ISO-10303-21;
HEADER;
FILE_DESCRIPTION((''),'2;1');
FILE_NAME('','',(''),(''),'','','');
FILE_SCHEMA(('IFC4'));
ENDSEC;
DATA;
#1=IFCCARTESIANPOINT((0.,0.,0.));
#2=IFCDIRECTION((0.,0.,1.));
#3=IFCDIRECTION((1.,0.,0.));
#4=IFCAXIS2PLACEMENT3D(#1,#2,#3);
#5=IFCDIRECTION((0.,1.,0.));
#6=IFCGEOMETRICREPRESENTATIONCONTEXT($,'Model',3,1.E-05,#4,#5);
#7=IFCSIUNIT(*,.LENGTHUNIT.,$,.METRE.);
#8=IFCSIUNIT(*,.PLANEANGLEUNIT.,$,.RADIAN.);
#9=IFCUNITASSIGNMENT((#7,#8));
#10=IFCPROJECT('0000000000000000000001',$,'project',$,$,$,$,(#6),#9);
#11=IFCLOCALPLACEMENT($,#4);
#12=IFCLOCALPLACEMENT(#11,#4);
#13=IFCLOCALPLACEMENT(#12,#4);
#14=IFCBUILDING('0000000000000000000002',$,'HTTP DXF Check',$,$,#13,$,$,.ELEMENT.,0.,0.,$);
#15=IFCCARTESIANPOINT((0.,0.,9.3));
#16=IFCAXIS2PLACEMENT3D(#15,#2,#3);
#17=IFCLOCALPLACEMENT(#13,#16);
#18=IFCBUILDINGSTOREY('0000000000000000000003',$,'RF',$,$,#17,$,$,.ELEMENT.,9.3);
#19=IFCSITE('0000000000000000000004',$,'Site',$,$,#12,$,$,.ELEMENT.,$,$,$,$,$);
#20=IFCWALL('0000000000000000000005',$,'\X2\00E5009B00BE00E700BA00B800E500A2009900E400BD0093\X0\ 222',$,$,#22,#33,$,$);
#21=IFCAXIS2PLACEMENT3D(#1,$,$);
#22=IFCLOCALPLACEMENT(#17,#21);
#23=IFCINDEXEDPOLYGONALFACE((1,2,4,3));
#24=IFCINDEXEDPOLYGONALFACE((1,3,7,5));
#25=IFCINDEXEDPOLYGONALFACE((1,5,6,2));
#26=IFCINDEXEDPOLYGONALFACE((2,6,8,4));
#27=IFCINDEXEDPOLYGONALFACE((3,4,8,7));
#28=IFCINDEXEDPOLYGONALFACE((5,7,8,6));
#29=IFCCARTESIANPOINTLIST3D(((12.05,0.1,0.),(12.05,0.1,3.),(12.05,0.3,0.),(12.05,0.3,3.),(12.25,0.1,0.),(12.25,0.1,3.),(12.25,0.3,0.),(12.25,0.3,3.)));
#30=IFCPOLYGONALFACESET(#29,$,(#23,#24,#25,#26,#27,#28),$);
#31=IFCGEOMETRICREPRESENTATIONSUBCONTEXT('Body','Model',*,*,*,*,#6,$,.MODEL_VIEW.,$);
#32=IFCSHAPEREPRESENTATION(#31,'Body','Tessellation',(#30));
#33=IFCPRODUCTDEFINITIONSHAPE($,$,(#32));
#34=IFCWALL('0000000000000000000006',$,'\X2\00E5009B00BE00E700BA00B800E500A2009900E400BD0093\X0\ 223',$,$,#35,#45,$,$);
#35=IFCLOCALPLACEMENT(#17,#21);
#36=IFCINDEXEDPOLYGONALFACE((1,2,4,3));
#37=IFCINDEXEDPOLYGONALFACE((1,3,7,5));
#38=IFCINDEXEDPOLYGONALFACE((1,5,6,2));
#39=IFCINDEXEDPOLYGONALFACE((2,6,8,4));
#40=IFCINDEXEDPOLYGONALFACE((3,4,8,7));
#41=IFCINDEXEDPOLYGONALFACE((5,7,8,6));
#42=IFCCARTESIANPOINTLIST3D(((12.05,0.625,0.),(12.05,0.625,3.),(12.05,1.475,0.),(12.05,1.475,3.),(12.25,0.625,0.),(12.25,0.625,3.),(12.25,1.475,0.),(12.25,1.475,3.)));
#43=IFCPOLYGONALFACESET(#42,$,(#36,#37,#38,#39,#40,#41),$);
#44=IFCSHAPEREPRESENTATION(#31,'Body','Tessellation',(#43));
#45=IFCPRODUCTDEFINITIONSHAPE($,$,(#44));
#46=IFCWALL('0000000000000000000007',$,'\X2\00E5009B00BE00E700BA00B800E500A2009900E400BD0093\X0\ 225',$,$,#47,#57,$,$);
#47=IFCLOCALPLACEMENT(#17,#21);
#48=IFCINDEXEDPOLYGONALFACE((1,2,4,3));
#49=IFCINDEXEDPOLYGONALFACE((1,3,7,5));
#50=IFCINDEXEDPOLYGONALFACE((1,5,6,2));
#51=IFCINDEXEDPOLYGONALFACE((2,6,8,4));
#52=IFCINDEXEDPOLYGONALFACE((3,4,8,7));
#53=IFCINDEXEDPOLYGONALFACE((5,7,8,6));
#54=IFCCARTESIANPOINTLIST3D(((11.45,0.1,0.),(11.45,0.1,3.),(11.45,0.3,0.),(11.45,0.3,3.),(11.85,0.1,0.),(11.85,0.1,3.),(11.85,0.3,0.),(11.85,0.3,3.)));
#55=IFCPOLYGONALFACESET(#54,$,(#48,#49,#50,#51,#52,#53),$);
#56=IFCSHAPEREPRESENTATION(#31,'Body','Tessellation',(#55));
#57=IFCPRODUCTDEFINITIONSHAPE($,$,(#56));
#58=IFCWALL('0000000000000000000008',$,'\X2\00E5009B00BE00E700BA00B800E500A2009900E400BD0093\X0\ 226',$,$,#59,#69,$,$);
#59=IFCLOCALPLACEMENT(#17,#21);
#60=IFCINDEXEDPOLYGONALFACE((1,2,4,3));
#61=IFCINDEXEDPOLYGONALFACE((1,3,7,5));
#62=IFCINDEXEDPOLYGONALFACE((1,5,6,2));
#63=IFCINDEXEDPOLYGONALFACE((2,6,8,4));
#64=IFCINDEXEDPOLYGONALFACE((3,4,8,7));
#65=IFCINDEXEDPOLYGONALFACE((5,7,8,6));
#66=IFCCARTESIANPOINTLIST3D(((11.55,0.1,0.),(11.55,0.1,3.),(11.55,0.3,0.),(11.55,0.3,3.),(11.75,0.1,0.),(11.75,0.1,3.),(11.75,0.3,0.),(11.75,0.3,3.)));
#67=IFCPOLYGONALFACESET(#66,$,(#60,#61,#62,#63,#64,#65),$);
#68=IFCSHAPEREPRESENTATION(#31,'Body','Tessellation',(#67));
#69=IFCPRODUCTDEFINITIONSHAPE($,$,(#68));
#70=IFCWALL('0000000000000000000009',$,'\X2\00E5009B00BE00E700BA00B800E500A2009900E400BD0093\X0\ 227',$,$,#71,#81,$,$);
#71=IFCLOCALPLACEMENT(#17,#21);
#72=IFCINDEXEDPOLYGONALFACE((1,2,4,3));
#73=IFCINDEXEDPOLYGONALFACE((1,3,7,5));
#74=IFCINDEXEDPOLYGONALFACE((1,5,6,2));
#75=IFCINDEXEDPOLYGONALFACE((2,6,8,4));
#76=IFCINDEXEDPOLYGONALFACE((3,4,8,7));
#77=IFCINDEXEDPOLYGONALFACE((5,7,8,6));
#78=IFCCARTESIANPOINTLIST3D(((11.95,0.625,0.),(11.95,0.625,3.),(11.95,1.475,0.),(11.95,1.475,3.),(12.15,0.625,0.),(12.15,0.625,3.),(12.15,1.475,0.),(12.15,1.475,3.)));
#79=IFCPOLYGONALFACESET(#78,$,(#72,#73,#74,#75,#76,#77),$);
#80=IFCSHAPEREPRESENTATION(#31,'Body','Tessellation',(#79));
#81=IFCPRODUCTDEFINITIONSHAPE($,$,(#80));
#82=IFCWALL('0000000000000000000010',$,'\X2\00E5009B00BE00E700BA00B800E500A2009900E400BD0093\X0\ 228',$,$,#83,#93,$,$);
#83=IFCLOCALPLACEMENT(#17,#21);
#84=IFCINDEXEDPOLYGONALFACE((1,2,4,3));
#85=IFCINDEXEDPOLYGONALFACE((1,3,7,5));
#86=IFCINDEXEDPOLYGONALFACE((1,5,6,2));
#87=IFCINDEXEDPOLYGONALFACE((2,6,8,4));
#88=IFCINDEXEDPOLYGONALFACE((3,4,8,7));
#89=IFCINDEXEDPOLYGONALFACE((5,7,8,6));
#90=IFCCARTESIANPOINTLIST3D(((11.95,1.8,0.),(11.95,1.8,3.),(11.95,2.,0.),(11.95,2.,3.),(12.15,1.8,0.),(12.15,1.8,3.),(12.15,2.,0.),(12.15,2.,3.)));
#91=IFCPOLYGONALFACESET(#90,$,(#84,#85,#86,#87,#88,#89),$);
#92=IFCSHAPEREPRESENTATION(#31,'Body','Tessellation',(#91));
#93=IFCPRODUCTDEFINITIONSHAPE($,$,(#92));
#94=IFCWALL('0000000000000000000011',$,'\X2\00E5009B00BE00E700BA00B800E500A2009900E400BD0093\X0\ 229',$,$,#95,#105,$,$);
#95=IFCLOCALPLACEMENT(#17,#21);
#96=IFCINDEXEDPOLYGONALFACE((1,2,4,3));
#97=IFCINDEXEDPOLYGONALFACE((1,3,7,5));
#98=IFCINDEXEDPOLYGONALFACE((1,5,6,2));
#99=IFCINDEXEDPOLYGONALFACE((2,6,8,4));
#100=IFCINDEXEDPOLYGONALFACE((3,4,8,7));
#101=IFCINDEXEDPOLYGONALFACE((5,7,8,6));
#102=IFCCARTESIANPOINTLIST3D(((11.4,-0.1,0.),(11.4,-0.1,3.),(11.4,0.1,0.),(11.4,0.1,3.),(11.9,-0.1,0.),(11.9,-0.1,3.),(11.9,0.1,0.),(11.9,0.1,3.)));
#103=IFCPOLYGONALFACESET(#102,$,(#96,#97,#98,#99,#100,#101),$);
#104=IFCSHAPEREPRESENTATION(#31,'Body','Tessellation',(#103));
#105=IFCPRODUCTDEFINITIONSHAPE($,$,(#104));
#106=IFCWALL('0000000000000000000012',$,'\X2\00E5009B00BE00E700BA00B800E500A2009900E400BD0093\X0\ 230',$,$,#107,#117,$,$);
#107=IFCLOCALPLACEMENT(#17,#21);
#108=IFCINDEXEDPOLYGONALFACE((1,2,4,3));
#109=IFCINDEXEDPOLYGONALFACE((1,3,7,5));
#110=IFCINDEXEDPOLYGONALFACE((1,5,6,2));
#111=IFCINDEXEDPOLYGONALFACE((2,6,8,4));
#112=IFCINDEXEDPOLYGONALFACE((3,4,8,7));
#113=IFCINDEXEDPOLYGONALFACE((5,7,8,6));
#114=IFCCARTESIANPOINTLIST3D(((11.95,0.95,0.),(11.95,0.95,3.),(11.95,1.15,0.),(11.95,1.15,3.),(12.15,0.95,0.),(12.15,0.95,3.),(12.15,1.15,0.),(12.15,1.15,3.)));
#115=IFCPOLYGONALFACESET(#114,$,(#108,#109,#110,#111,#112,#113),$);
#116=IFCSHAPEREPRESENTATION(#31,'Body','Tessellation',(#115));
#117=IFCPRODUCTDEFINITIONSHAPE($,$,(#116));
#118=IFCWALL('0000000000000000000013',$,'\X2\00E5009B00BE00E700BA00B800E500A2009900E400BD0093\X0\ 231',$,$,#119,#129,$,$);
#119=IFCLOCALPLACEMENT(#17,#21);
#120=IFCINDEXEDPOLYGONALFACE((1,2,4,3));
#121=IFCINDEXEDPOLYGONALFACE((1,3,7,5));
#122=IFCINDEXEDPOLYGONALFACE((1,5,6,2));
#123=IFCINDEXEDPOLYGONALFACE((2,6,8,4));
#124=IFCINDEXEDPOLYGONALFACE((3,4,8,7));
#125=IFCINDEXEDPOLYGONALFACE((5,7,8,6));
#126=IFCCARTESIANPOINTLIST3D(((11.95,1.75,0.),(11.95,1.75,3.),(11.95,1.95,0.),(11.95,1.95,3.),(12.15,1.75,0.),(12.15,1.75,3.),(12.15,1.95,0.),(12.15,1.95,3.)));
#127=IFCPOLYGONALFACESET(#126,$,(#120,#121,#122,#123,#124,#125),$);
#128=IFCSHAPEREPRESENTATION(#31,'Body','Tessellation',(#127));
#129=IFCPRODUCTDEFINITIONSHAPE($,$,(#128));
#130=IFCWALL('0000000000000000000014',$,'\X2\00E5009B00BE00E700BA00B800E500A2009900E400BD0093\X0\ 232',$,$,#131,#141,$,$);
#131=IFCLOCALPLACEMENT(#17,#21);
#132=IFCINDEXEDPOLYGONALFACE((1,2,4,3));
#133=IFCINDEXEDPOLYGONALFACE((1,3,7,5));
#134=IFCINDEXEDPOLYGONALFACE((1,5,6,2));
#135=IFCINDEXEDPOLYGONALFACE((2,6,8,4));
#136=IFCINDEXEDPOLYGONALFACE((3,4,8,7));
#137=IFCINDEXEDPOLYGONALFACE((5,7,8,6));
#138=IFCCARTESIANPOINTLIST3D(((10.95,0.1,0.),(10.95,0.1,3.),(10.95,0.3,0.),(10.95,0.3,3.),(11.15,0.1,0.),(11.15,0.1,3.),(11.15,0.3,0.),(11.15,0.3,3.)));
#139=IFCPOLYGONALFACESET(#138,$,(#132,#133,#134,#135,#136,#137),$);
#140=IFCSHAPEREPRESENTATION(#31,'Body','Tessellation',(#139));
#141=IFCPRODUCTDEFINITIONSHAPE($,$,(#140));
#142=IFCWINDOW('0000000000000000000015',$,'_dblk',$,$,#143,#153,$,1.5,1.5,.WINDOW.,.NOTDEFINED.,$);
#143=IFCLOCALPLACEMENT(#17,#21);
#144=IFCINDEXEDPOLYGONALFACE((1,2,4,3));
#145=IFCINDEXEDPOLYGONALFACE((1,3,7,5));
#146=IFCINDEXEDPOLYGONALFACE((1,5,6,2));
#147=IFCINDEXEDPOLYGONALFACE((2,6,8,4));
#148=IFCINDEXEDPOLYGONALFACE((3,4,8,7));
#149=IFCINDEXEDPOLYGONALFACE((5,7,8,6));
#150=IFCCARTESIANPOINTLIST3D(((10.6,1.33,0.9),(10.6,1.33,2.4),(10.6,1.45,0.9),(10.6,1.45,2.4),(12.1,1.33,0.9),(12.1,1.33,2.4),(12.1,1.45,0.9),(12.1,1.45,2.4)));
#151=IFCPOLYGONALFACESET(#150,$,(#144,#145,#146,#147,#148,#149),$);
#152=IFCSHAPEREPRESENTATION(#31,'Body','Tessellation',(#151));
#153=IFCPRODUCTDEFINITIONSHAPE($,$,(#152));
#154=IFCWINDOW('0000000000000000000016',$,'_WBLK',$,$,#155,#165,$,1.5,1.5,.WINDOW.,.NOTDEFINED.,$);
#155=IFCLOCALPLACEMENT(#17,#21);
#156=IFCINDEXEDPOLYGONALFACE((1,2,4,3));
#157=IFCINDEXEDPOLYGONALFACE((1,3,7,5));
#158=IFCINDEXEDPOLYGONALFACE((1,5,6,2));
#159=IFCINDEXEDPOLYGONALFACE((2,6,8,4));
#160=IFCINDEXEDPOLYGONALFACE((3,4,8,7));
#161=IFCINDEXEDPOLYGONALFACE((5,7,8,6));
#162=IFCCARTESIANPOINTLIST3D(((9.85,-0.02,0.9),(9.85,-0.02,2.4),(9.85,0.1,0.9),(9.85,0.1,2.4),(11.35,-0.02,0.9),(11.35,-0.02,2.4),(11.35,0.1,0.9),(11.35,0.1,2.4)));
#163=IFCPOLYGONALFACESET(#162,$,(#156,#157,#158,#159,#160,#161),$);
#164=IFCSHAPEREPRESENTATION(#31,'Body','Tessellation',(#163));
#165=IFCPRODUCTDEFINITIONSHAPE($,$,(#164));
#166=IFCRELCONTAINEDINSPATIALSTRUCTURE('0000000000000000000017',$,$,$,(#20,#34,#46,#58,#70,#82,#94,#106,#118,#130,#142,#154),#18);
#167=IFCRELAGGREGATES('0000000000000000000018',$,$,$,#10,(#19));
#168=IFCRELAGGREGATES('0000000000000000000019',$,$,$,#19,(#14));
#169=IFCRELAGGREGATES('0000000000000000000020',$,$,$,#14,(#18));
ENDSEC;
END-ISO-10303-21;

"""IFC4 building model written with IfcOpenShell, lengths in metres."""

from ifc_helpers import new_model, si_unit, direction, frame, frame_2d, origin_with_axes, place, context, subcontext, project, spatial, rectangle, extrude, element, save


model = new_model("IFC4")

# Units and contexts
model_context = context("Model", 3, precision=1e-05, world=origin_with_axes(), true_north=direction((0.0, 1.0, 0.0)))
body_context = subcontext(model_context, "Body", "Model", "MODEL_VIEW")
ifc_project = project(units=[si_unit("LENGTHUNIT", "METRE"), si_unit("PLANEANGLEUNIT", "RADIAN")], contexts=[model_context])

# Site, building, storey
placement = place(None, origin_with_axes())
site_placement = place(placement, origin_with_axes())
site = spatial("IfcSite", under=ifc_project, at=site_placement, Name="Site", CompositionType="ELEMENT")
building_placement = place(site_placement, origin_with_axes())
building = spatial("IfcBuilding", under=site, at=building_placement, Name="HTTP DXF Check", CompositionType="ELEMENT", ElevationOfRefHeight=0.0, ElevationOfTerrain=0.0)
storey_placement = place(building_placement, frame((0.0, 0.0, 9.3), z_axis=(0.0, 0.0, 1.0), x_axis=(1.0, 0.0, 0.0)))
storey = spatial("IfcBuildingStorey", under=building, at=storey_placement, Name="RF", CompositionType="ELEMENT", Elevation=9.3)

# Walls
for number, where, z_axis, x_axis, name in (
    (1, (12.15, 0.2, 0.0), (0.0, 0.0, 1.0), (0.0, -1.0, 0.0), "å\u009b¾çº¸å¢\u0099ä½\u0093 222"),
):
    element("IfcWall", number, at=place(storey_placement, frame(where, z_axis=z_axis, x_axis=x_axis)), inside=storey, Name=name, context=body_context, shape_type="SweptSolid", body=[
        extrude(rectangle(XDim=0.2, YDim=0.2, at=frame_2d((0.0, 0.0), x_axis=(1.0, 0.0, 0.0))), frame((0.0, 0.0, 0.0), z_axis=(0.0, 0.0, 1.0)), (0.0, 0.0, 1.0), 3.0),
    ])
wall_1_placement = place(storey_placement, frame((12.15, 1.05, 0.0), z_axis=(0.0, 0.0, 1.0), x_axis=(0.0, -1.0, 0.0)))
element("IfcWall", 2, at=wall_1_placement, inside=storey, Name="å\u009b¾çº¸å¢\u0099ä½\u0093 223", context=body_context, shape_type="SweptSolid", body=[
    extrude(rectangle(XDim=0.85, YDim=0.2, at=frame_2d((0.0, 0.0), x_axis=(1.0, 0.0, 0.0))), frame((0.0, 0.0, 0.0), z_axis=(0.0, 0.0, 1.0)), (0.0, 0.0, 1.0), 3.0),
])
wall_2_placement = place(storey_placement, frame((11.65, 0.2, 0.0), z_axis=(0.0, 0.0, 1.0), x_axis=(1.0, 0.0, 0.0)))
element("IfcWall", 3, at=wall_2_placement, inside=storey, Name="å\u009b¾çº¸å¢\u0099ä½\u0093 225", context=body_context, shape_type="SweptSolid", body=[
    extrude(rectangle(XDim=0.4, YDim=0.2, at=frame_2d((0.0, 0.0), x_axis=(1.0, 0.0, 0.0))), frame((0.0, 0.0, 0.0), z_axis=(0.0, 0.0, 1.0)), (0.0, 0.0, 1.0), 3.0),
])
wall_3_placement = place(storey_placement, frame((11.65, 0.2, 0.0), z_axis=(0.0, 0.0, 1.0), x_axis=(0.0, -1.0, 0.0)))
element("IfcWall", 4, at=wall_3_placement, inside=storey, Name="å\u009b¾çº¸å¢\u0099ä½\u0093 226", context=body_context, shape_type="SweptSolid", body=[
    extrude(rectangle(XDim=0.2, YDim=0.2, at=frame_2d((0.0, 0.0), x_axis=(1.0, 0.0, 0.0))), frame((0.0, 0.0, 0.0), z_axis=(0.0, 0.0, 1.0)), (0.0, 0.0, 1.0), 3.0),
])
wall_4_placement = place(storey_placement, frame((12.05, 1.05, 0.0), z_axis=(0.0, 0.0, 1.0), x_axis=(0.0, -1.0, 0.0)))
element("IfcWall", 5, at=wall_4_placement, inside=storey, Name="å\u009b¾çº¸å¢\u0099ä½\u0093 227", context=body_context, shape_type="SweptSolid", body=[
    extrude(rectangle(XDim=0.85, YDim=0.2, at=frame_2d((0.0, 0.0), x_axis=(1.0, 0.0, 0.0))), frame((0.0, 0.0, 0.0), z_axis=(0.0, 0.0, 1.0)), (0.0, 0.0, 1.0), 3.0),
])
wall_5_placement = place(storey_placement, frame((12.05, 1.9, 0.0), z_axis=(0.0, 0.0, 1.0), x_axis=(0.0, -1.0, 0.0)))
element("IfcWall", 6, at=wall_5_placement, inside=storey, Name="å\u009b¾çº¸å¢\u0099ä½\u0093 228", context=body_context, shape_type="SweptSolid", body=[
    extrude(rectangle(XDim=0.2, YDim=0.2, at=frame_2d((0.0, 0.0), x_axis=(1.0, 0.0, 0.0))), frame((0.0, 0.0, 0.0), z_axis=(0.0, 0.0, 1.0)), (0.0, 0.0, 1.0), 3.0),
])
wall_6_placement = place(storey_placement, frame((11.65, 0.0, 0.0), z_axis=(0.0, 0.0, 1.0), x_axis=(1.0, 0.0, 0.0)))
element("IfcWall", 7, at=wall_6_placement, inside=storey, Name="å\u009b¾çº¸å¢\u0099ä½\u0093 229", context=body_context, shape_type="SweptSolid", body=[
    extrude(rectangle(XDim=0.5, YDim=0.2, at=frame_2d((0.0, 0.0), x_axis=(1.0, 0.0, 0.0))), frame((0.0, 0.0, 0.0), z_axis=(0.0, 0.0, 1.0)), (0.0, 0.0, 1.0), 3.0),
])
for number, where, z_axis, x_axis, name in (
    (8, (12.05, 1.05, 0.0), (0.0, 0.0, 1.0), (1.0, 0.0, 0.0), "å\u009b¾çº¸å¢\u0099ä½\u0093 230"),
    (9, (12.05, 1.85, 0.0), (0.0, 0.0, 1.0), (1.0, 0.0, 0.0), "å\u009b¾çº¸å¢\u0099ä½\u0093 231"),
    (10, (11.05, 0.2, 0.0), (0.0, 0.0, 1.0), (0.0, -1.0, 0.0), "å\u009b¾çº¸å¢\u0099ä½\u0093 232"),
):
    element("IfcWall", number, at=place(storey_placement, frame(where, z_axis=z_axis, x_axis=x_axis)), inside=storey, Name=name, context=body_context, shape_type="SweptSolid", body=[
        extrude(rectangle(XDim=0.2, YDim=0.2, at=frame_2d((0.0, 0.0), x_axis=(1.0, 0.0, 0.0))), frame((0.0, 0.0, 0.0), z_axis=(0.0, 0.0, 1.0)), (0.0, 0.0, 1.0), 3.0),
    ])

# Windows
for number, where, z_axis, x_axis, name in (
    (11, (11.35, 1.39, 0.9), (0.0, 0.0, 1.0), (1.0, 0.0, 0.0), "_dblk"),
    (12, (10.6, 0.04, 0.9), (0.0, 0.0, 1.0), (1.0, 0.0, 0.0), "_WBLK"),
):
    element("IfcWindow", number, at=place(storey_placement, frame(where, z_axis=z_axis, x_axis=x_axis)), inside=storey, Name=name, OverallHeight=1.5, OverallWidth=1.5, PartitioningType="NOTDEFINED", PredefinedType="WINDOW", context=body_context, shape_type="SweptSolid", body=[
        extrude(rectangle(XDim=1.5, YDim=0.12, at=frame_2d((0.0, 0.0), x_axis=(1.0, 0.0, 0.0))), frame((0.0, 0.0, 0.0), z_axis=(0.0, 0.0, 1.0)), (0.0, 0.0, 1.0), 1.5),
    ])

save(model, "model.ifc")
